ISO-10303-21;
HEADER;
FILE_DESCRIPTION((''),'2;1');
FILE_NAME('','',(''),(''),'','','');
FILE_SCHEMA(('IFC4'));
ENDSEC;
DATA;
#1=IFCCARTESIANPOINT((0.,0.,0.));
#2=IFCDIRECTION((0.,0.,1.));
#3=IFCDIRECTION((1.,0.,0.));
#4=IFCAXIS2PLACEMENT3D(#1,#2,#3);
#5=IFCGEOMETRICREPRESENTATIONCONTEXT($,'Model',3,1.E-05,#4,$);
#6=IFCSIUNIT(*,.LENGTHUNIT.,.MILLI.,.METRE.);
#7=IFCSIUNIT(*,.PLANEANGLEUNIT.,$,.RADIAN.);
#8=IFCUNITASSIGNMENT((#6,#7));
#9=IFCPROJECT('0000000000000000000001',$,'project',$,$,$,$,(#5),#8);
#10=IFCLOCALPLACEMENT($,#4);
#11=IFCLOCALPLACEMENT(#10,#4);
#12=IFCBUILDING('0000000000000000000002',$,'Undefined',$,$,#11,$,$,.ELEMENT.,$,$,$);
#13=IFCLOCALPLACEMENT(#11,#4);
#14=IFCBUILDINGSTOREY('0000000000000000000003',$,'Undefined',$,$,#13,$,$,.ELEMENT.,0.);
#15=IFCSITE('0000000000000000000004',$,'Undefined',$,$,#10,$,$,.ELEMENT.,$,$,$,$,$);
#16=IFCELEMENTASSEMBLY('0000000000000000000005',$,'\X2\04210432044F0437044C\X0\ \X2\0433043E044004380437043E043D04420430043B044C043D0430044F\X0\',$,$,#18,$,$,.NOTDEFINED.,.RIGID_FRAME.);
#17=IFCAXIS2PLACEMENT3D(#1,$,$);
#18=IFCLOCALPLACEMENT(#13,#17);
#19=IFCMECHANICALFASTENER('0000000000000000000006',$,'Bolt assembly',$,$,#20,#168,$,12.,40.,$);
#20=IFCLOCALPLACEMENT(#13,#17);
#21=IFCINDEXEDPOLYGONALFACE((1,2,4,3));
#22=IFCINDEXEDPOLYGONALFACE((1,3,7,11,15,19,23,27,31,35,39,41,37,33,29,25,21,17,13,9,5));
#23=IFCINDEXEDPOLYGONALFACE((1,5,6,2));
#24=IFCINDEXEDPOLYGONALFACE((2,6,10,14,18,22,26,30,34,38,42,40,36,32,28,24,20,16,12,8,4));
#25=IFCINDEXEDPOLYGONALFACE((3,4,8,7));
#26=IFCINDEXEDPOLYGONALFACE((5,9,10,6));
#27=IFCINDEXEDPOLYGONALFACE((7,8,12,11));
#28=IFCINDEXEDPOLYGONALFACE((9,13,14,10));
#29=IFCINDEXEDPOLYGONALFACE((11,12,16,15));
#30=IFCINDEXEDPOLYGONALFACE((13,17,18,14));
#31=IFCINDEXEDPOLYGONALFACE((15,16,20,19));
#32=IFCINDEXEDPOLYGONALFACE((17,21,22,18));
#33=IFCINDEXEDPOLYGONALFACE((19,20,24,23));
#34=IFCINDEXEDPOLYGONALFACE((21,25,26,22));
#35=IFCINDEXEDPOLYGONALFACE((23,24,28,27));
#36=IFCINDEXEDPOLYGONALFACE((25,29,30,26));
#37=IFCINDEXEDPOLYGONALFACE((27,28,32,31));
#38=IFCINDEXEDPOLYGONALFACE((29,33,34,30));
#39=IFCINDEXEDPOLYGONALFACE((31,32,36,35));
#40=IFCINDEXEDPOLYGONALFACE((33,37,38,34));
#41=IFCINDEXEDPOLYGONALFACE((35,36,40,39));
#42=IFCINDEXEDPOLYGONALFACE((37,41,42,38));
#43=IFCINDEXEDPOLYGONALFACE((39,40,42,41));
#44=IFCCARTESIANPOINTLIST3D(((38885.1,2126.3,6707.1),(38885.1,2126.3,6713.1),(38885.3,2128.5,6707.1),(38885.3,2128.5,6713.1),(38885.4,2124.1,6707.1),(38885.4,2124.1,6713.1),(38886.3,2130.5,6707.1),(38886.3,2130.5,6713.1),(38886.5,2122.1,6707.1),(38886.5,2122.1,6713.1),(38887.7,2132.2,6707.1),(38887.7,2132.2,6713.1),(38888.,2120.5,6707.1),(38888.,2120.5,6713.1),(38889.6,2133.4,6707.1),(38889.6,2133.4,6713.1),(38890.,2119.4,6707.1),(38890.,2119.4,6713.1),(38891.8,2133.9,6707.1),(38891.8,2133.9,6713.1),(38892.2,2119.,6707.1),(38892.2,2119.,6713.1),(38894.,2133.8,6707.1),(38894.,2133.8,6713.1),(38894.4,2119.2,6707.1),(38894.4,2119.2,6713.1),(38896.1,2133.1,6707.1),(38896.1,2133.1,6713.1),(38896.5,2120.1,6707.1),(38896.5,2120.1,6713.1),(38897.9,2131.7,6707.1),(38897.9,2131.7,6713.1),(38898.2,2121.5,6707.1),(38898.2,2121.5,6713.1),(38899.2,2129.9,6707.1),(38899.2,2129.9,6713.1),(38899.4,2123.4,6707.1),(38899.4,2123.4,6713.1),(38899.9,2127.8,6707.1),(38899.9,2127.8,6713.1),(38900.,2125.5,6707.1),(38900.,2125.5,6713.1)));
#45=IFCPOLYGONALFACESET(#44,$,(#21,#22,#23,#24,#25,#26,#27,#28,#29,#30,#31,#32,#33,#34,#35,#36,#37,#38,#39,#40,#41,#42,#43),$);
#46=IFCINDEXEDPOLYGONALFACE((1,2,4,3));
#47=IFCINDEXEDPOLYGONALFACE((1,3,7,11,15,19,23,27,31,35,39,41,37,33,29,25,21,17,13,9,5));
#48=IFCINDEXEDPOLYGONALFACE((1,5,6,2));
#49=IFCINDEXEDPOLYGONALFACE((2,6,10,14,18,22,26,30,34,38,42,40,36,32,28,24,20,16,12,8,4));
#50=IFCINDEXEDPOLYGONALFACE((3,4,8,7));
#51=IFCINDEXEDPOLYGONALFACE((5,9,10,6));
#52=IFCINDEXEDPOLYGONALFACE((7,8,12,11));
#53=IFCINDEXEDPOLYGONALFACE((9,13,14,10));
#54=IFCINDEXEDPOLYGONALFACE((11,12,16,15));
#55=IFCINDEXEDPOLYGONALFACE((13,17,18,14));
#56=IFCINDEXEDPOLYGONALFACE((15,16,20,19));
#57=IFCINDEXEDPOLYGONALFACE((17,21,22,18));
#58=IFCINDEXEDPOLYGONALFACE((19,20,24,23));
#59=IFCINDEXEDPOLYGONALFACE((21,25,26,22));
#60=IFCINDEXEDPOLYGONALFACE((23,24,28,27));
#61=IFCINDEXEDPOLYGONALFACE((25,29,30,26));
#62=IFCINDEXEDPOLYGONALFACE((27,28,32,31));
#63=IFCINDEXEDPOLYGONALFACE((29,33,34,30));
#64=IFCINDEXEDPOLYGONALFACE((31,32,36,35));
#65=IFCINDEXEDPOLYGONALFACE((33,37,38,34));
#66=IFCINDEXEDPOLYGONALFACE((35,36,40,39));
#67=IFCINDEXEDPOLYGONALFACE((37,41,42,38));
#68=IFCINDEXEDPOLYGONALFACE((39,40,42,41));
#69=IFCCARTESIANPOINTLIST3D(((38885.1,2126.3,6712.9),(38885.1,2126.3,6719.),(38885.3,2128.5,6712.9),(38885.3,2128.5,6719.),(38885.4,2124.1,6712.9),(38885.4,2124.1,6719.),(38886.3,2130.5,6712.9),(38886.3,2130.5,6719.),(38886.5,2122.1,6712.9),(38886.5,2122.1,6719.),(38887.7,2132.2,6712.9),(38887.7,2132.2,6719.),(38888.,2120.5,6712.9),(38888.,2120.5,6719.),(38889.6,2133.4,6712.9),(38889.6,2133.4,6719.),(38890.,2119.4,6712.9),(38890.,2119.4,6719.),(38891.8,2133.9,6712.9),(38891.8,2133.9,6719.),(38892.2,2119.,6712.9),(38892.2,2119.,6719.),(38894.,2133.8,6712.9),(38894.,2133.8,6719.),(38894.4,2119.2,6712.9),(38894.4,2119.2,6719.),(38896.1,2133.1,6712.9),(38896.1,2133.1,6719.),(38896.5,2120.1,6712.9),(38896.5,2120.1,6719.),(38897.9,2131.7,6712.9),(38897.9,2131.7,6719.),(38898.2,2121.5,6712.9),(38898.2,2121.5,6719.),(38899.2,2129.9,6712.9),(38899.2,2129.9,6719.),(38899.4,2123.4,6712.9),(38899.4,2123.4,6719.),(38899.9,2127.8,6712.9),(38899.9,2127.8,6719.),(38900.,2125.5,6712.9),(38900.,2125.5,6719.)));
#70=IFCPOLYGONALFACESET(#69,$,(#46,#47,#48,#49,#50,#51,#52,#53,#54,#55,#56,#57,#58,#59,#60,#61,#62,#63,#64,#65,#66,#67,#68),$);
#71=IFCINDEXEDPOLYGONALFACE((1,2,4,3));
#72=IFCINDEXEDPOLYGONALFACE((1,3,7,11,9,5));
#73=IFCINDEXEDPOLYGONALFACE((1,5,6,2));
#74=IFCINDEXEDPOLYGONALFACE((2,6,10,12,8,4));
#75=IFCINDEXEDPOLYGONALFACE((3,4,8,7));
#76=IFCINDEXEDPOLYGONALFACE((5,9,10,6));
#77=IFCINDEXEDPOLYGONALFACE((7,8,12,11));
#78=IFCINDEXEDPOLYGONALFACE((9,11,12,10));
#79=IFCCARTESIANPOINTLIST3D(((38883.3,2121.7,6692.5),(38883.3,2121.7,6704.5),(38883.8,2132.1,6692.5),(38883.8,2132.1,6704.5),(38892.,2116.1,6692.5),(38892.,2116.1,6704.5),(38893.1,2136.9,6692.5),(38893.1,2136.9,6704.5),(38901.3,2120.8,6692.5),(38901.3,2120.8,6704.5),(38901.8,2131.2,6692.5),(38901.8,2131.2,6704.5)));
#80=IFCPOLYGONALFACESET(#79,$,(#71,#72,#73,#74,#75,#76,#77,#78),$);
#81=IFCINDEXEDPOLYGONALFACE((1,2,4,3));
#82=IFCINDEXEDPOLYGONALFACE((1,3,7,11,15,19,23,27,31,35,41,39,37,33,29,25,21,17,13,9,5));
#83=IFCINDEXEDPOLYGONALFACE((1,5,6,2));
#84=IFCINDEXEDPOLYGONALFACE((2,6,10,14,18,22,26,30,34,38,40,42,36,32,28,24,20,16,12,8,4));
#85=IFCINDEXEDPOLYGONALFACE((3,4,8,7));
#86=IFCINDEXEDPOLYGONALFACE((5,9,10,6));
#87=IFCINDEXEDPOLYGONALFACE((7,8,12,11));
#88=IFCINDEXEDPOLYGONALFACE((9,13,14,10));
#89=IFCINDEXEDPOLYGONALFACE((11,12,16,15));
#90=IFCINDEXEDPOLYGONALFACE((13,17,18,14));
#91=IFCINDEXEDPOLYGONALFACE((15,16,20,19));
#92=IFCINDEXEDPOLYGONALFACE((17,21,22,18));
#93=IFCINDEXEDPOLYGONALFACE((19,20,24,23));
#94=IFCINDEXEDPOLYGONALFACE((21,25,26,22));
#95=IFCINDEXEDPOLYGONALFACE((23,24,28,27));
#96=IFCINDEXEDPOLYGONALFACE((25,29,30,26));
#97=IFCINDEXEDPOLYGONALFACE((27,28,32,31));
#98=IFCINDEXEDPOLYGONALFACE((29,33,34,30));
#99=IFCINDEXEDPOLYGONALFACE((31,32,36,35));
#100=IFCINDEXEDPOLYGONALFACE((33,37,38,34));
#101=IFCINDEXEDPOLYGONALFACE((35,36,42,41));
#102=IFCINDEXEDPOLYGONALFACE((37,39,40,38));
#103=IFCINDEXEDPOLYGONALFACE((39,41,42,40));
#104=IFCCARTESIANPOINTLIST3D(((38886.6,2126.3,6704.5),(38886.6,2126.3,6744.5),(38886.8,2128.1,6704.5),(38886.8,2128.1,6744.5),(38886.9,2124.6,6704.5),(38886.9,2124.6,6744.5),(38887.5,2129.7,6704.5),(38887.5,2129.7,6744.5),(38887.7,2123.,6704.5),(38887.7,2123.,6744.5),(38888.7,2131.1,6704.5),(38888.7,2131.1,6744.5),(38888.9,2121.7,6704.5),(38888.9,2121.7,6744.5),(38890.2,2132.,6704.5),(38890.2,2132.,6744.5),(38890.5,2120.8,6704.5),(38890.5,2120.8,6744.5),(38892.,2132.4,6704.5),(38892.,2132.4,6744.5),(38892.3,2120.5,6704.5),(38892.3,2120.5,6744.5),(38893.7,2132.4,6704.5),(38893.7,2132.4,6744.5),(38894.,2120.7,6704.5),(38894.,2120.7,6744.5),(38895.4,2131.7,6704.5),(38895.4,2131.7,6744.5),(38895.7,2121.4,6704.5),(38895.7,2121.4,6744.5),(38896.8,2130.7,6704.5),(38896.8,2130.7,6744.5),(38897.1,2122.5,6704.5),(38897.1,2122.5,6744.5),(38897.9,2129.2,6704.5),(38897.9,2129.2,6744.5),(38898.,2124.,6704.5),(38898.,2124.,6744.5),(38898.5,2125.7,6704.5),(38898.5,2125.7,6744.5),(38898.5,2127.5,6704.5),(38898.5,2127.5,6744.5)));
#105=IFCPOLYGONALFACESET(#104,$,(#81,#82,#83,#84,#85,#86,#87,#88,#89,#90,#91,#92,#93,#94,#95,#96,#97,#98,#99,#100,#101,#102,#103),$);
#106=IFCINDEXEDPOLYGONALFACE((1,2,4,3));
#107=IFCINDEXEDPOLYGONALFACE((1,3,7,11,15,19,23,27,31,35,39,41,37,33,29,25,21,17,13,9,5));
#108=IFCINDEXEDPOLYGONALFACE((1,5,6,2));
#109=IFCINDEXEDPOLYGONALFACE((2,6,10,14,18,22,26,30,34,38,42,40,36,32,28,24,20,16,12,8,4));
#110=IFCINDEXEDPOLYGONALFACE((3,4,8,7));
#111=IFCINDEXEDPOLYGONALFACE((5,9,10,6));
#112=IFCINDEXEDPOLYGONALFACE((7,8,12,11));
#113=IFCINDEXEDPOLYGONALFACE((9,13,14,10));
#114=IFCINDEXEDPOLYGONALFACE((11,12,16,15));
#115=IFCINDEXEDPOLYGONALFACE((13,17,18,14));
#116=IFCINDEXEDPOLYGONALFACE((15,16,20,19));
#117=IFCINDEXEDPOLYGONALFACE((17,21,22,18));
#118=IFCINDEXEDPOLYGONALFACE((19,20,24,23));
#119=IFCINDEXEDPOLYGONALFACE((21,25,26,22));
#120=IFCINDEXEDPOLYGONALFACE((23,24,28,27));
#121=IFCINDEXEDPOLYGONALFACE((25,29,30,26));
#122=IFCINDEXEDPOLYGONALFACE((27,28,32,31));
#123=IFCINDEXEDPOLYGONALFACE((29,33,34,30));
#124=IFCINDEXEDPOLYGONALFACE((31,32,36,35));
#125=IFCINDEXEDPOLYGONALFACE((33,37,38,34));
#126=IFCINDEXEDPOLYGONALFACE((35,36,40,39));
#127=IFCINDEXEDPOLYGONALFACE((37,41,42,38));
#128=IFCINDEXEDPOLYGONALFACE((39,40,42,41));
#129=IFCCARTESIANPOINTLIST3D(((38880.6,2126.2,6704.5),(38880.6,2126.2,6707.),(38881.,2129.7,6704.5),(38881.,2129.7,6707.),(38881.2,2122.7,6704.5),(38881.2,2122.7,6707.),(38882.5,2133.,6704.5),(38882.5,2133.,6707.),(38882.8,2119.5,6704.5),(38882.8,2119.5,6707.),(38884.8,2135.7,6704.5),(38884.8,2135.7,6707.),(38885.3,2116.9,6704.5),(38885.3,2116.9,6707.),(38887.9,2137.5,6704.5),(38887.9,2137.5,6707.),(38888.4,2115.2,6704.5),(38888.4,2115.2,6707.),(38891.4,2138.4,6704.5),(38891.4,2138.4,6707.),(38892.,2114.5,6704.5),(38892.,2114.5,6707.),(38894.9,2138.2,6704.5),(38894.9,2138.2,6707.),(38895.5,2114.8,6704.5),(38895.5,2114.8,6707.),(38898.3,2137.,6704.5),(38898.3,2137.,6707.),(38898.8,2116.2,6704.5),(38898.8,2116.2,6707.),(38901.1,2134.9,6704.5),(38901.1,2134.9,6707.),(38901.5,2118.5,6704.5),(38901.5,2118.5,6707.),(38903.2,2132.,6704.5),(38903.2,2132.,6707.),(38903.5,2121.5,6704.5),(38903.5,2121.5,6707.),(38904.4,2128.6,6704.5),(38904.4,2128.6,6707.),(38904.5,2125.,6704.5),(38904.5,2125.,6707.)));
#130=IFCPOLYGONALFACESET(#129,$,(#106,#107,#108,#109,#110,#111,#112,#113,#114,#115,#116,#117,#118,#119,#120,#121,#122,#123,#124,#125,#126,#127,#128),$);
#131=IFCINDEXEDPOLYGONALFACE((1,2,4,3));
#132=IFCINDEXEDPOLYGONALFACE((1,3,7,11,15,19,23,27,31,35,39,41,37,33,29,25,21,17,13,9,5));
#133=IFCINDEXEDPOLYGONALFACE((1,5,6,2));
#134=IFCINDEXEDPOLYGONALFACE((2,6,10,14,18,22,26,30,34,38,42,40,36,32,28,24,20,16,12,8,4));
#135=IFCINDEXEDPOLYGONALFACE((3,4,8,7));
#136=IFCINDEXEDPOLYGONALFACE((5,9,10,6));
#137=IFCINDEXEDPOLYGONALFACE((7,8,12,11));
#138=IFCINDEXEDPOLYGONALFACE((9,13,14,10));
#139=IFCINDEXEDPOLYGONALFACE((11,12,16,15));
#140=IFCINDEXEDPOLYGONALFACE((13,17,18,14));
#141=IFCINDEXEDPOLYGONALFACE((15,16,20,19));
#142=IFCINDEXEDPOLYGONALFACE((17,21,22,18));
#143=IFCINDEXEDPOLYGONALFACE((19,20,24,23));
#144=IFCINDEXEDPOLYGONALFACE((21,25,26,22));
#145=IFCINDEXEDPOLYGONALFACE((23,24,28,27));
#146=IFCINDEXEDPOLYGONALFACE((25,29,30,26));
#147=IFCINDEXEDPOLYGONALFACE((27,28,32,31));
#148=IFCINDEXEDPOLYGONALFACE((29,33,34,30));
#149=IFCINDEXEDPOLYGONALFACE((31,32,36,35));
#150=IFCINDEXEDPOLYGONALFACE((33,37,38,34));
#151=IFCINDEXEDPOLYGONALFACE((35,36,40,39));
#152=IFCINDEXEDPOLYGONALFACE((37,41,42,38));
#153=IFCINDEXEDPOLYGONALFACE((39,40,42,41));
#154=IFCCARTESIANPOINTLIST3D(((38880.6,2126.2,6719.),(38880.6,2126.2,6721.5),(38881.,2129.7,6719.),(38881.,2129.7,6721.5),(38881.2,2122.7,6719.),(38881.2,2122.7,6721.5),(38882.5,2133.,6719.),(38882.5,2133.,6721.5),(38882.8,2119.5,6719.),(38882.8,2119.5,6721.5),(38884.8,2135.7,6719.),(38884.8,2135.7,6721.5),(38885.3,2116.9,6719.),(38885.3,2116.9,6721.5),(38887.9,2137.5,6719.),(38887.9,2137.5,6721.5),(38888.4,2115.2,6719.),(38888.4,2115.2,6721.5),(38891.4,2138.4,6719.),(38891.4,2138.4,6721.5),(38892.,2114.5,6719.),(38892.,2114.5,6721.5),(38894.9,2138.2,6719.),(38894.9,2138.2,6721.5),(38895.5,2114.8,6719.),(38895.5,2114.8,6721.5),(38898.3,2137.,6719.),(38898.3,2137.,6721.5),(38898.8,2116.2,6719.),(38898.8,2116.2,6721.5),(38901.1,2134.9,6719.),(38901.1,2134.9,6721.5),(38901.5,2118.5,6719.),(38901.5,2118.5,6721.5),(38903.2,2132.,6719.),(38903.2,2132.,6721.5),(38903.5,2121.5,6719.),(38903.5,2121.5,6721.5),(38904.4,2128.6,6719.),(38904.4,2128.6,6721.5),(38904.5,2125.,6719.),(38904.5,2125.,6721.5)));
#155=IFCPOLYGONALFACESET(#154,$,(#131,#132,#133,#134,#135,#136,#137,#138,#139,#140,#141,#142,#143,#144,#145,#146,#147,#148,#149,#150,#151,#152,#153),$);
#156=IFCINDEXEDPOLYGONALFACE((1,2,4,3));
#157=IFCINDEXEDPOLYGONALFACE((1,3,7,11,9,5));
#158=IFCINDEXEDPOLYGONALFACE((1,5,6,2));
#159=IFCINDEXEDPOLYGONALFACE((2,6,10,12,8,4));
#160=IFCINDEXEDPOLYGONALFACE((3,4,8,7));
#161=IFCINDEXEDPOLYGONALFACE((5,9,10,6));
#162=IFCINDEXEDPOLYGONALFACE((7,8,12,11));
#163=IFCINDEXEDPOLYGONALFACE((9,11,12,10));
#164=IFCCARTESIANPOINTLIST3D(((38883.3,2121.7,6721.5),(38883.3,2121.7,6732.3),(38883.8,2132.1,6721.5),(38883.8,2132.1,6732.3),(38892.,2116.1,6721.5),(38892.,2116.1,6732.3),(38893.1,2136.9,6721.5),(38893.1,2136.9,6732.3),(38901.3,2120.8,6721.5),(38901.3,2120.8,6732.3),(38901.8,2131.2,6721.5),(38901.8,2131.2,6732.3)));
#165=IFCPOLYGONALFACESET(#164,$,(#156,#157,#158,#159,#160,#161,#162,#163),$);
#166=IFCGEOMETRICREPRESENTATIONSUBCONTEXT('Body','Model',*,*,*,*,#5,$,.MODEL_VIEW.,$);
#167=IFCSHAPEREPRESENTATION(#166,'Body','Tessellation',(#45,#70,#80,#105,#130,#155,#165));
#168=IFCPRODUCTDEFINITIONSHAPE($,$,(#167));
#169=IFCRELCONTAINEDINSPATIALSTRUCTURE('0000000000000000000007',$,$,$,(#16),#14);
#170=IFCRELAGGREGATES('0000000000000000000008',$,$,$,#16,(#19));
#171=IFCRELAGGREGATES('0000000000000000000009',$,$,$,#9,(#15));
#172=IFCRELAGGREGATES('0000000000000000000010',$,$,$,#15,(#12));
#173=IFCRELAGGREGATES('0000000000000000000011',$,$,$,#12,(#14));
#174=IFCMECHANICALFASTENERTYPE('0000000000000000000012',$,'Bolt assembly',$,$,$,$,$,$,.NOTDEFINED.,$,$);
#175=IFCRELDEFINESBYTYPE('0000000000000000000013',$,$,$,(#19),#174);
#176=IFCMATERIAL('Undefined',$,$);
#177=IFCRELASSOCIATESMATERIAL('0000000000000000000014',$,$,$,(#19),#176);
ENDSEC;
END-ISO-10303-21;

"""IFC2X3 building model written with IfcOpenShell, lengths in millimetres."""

from ifc_helpers import new_model, si_unit, frame, origin_with_axes, origin_2d_with_axis, place, context, subcontext, project, spatial, polyline, circle, outline, extrude, source, transform, mapped, material, type_object, element, aggregate, save


model = new_model("IFC2X3")

# Units and contexts
model_context = context("Model", 3, precision=1e-05, world=origin_with_axes())
body_context = subcontext(model_context, "Body", "Model", "MODEL_VIEW")
ifc_project = project(units=[si_unit("LENGTHUNIT", "METRE", prefix="MILLI"), si_unit("PLANEANGLEUNIT", "RADIAN")], contexts=[model_context])

# Site, building, storey
site_placement = place(None, origin_with_axes())
site = spatial("IfcSite", under=ifc_project, at=site_placement, Name="Undefined", CompositionType="ELEMENT")
building_placement = place(site_placement, origin_with_axes())
building = spatial("IfcBuilding", under=site, at=building_placement, Name="Undefined", CompositionType="ELEMENT")
storey_placement = place(building_placement, origin_with_axes())
storey = spatial("IfcBuildingStorey", under=building, at=storey_placement, Name="Undefined", CompositionType="ELEMENT", Elevation=0.0)

# Element assembly
assembly_1_placement = place(storey_placement, origin_with_axes())
assembly_1 = element("IfcElementAssembly", 1, at=assembly_1_placement, inside=storey, Name="Связь горизонтальная", AssemblyPlace="NOTDEFINED", PredefinedType="RIGID_FRAME")

# Mechanical fastener
ifc_material_1 = material(Name="Undefined")
mechanical_fastener_type = type_object("IfcMechanicalFastenerType", Name="Bolt assembly")
shared_shape_1 = source(origin_with_axes(), body_context, "Body", "SweptSolid", [
    extrude(circle(Radius=7.5, at=origin_2d_with_axis()), frame((0.0, 0.1, 0.0), z_axis=(0.0, 1.0, 0.0), x_axis=(1.0, 0.0, 0.0)), (0.0, 0.0, 1.0), 6.0),
    extrude(circle(Radius=7.5, at=origin_2d_with_axis()), frame((0.0, 5.9, 0.0), z_axis=(0.0, 1.0, 0.0), x_axis=(1.0, 0.0, 0.0)), (0.0, 0.0, 1.0), 6.1),
    extrude(outline(polyline([(10.4, 0.0), (5.2, 9.0), (-5.2, 9.0), (-10.4, 0.0), (-5.2, -9.0), (5.2, -9.0), (10.4, 0.0)])), frame((0.0, -14.5, 0.0), z_axis=(0.0, 1.0, 0.0), x_axis=(1.0, 0.0, 0.0)), (0.0, 0.0, 1.0), 12.0),
    extrude(circle(Radius=6.0, at=origin_2d_with_axis()), frame((0.0, -2.5, 0.0), z_axis=(0.0, 1.0, 0.0), x_axis=(1.0, 0.0, 0.0)), (0.0, 0.0, 1.0), 40.0),
    extrude(circle(Radius=12.0, at=origin_2d_with_axis()), frame((0.0, -2.5, 0.0), z_axis=(0.0, 1.0, 0.0), x_axis=(1.0, 0.0, 0.0)), (0.0, 0.0, 1.0), 2.5),
    extrude(circle(Radius=12.0, at=origin_2d_with_axis()), frame((0.0, 12.0, 0.0), z_axis=(0.0, 1.0, 0.0), x_axis=(1.0, 0.0, 0.0)), (0.0, 0.0, 1.0), 2.5),
    extrude(outline(polyline([(10.4, 0.0), (5.2, 9.0), (-5.2, 9.0), (-10.4, 0.0), (-5.2, -9.0), (5.2, -9.0), (10.4, 0.0)])), frame((0.0, 14.5, 0.0), z_axis=(0.0, 1.0, 0.0), x_axis=(1.0, 0.0, 0.0)), (0.0, 0.0, 1.0), 10.8),
])
mechanical_fastener_1_placement = place(assembly_1_placement, frame((38892.6, 2126.5, 6707.0), z_axis=(0.542525, 0.840039, 0.0), x_axis=(-0.840039, 0.542525, 0.0)))
mechanical_fastener_1 = element("IfcMechanicalFastener", 2, at=mechanical_fastener_1_placement, type_object=mechanical_fastener_type, material=ifc_material_1, Name="Bolt assembly", NominalDiameter=12.0, NominalLength=40.0, context=body_context, shape_type="MappedRepresentation", body=[
    mapped(shared_shape_1, transform((0.0, 0.0, 0.0))),
])
aggregate(assembly_1, [mechanical_fastener_1])

save(model, "model.ifc")
